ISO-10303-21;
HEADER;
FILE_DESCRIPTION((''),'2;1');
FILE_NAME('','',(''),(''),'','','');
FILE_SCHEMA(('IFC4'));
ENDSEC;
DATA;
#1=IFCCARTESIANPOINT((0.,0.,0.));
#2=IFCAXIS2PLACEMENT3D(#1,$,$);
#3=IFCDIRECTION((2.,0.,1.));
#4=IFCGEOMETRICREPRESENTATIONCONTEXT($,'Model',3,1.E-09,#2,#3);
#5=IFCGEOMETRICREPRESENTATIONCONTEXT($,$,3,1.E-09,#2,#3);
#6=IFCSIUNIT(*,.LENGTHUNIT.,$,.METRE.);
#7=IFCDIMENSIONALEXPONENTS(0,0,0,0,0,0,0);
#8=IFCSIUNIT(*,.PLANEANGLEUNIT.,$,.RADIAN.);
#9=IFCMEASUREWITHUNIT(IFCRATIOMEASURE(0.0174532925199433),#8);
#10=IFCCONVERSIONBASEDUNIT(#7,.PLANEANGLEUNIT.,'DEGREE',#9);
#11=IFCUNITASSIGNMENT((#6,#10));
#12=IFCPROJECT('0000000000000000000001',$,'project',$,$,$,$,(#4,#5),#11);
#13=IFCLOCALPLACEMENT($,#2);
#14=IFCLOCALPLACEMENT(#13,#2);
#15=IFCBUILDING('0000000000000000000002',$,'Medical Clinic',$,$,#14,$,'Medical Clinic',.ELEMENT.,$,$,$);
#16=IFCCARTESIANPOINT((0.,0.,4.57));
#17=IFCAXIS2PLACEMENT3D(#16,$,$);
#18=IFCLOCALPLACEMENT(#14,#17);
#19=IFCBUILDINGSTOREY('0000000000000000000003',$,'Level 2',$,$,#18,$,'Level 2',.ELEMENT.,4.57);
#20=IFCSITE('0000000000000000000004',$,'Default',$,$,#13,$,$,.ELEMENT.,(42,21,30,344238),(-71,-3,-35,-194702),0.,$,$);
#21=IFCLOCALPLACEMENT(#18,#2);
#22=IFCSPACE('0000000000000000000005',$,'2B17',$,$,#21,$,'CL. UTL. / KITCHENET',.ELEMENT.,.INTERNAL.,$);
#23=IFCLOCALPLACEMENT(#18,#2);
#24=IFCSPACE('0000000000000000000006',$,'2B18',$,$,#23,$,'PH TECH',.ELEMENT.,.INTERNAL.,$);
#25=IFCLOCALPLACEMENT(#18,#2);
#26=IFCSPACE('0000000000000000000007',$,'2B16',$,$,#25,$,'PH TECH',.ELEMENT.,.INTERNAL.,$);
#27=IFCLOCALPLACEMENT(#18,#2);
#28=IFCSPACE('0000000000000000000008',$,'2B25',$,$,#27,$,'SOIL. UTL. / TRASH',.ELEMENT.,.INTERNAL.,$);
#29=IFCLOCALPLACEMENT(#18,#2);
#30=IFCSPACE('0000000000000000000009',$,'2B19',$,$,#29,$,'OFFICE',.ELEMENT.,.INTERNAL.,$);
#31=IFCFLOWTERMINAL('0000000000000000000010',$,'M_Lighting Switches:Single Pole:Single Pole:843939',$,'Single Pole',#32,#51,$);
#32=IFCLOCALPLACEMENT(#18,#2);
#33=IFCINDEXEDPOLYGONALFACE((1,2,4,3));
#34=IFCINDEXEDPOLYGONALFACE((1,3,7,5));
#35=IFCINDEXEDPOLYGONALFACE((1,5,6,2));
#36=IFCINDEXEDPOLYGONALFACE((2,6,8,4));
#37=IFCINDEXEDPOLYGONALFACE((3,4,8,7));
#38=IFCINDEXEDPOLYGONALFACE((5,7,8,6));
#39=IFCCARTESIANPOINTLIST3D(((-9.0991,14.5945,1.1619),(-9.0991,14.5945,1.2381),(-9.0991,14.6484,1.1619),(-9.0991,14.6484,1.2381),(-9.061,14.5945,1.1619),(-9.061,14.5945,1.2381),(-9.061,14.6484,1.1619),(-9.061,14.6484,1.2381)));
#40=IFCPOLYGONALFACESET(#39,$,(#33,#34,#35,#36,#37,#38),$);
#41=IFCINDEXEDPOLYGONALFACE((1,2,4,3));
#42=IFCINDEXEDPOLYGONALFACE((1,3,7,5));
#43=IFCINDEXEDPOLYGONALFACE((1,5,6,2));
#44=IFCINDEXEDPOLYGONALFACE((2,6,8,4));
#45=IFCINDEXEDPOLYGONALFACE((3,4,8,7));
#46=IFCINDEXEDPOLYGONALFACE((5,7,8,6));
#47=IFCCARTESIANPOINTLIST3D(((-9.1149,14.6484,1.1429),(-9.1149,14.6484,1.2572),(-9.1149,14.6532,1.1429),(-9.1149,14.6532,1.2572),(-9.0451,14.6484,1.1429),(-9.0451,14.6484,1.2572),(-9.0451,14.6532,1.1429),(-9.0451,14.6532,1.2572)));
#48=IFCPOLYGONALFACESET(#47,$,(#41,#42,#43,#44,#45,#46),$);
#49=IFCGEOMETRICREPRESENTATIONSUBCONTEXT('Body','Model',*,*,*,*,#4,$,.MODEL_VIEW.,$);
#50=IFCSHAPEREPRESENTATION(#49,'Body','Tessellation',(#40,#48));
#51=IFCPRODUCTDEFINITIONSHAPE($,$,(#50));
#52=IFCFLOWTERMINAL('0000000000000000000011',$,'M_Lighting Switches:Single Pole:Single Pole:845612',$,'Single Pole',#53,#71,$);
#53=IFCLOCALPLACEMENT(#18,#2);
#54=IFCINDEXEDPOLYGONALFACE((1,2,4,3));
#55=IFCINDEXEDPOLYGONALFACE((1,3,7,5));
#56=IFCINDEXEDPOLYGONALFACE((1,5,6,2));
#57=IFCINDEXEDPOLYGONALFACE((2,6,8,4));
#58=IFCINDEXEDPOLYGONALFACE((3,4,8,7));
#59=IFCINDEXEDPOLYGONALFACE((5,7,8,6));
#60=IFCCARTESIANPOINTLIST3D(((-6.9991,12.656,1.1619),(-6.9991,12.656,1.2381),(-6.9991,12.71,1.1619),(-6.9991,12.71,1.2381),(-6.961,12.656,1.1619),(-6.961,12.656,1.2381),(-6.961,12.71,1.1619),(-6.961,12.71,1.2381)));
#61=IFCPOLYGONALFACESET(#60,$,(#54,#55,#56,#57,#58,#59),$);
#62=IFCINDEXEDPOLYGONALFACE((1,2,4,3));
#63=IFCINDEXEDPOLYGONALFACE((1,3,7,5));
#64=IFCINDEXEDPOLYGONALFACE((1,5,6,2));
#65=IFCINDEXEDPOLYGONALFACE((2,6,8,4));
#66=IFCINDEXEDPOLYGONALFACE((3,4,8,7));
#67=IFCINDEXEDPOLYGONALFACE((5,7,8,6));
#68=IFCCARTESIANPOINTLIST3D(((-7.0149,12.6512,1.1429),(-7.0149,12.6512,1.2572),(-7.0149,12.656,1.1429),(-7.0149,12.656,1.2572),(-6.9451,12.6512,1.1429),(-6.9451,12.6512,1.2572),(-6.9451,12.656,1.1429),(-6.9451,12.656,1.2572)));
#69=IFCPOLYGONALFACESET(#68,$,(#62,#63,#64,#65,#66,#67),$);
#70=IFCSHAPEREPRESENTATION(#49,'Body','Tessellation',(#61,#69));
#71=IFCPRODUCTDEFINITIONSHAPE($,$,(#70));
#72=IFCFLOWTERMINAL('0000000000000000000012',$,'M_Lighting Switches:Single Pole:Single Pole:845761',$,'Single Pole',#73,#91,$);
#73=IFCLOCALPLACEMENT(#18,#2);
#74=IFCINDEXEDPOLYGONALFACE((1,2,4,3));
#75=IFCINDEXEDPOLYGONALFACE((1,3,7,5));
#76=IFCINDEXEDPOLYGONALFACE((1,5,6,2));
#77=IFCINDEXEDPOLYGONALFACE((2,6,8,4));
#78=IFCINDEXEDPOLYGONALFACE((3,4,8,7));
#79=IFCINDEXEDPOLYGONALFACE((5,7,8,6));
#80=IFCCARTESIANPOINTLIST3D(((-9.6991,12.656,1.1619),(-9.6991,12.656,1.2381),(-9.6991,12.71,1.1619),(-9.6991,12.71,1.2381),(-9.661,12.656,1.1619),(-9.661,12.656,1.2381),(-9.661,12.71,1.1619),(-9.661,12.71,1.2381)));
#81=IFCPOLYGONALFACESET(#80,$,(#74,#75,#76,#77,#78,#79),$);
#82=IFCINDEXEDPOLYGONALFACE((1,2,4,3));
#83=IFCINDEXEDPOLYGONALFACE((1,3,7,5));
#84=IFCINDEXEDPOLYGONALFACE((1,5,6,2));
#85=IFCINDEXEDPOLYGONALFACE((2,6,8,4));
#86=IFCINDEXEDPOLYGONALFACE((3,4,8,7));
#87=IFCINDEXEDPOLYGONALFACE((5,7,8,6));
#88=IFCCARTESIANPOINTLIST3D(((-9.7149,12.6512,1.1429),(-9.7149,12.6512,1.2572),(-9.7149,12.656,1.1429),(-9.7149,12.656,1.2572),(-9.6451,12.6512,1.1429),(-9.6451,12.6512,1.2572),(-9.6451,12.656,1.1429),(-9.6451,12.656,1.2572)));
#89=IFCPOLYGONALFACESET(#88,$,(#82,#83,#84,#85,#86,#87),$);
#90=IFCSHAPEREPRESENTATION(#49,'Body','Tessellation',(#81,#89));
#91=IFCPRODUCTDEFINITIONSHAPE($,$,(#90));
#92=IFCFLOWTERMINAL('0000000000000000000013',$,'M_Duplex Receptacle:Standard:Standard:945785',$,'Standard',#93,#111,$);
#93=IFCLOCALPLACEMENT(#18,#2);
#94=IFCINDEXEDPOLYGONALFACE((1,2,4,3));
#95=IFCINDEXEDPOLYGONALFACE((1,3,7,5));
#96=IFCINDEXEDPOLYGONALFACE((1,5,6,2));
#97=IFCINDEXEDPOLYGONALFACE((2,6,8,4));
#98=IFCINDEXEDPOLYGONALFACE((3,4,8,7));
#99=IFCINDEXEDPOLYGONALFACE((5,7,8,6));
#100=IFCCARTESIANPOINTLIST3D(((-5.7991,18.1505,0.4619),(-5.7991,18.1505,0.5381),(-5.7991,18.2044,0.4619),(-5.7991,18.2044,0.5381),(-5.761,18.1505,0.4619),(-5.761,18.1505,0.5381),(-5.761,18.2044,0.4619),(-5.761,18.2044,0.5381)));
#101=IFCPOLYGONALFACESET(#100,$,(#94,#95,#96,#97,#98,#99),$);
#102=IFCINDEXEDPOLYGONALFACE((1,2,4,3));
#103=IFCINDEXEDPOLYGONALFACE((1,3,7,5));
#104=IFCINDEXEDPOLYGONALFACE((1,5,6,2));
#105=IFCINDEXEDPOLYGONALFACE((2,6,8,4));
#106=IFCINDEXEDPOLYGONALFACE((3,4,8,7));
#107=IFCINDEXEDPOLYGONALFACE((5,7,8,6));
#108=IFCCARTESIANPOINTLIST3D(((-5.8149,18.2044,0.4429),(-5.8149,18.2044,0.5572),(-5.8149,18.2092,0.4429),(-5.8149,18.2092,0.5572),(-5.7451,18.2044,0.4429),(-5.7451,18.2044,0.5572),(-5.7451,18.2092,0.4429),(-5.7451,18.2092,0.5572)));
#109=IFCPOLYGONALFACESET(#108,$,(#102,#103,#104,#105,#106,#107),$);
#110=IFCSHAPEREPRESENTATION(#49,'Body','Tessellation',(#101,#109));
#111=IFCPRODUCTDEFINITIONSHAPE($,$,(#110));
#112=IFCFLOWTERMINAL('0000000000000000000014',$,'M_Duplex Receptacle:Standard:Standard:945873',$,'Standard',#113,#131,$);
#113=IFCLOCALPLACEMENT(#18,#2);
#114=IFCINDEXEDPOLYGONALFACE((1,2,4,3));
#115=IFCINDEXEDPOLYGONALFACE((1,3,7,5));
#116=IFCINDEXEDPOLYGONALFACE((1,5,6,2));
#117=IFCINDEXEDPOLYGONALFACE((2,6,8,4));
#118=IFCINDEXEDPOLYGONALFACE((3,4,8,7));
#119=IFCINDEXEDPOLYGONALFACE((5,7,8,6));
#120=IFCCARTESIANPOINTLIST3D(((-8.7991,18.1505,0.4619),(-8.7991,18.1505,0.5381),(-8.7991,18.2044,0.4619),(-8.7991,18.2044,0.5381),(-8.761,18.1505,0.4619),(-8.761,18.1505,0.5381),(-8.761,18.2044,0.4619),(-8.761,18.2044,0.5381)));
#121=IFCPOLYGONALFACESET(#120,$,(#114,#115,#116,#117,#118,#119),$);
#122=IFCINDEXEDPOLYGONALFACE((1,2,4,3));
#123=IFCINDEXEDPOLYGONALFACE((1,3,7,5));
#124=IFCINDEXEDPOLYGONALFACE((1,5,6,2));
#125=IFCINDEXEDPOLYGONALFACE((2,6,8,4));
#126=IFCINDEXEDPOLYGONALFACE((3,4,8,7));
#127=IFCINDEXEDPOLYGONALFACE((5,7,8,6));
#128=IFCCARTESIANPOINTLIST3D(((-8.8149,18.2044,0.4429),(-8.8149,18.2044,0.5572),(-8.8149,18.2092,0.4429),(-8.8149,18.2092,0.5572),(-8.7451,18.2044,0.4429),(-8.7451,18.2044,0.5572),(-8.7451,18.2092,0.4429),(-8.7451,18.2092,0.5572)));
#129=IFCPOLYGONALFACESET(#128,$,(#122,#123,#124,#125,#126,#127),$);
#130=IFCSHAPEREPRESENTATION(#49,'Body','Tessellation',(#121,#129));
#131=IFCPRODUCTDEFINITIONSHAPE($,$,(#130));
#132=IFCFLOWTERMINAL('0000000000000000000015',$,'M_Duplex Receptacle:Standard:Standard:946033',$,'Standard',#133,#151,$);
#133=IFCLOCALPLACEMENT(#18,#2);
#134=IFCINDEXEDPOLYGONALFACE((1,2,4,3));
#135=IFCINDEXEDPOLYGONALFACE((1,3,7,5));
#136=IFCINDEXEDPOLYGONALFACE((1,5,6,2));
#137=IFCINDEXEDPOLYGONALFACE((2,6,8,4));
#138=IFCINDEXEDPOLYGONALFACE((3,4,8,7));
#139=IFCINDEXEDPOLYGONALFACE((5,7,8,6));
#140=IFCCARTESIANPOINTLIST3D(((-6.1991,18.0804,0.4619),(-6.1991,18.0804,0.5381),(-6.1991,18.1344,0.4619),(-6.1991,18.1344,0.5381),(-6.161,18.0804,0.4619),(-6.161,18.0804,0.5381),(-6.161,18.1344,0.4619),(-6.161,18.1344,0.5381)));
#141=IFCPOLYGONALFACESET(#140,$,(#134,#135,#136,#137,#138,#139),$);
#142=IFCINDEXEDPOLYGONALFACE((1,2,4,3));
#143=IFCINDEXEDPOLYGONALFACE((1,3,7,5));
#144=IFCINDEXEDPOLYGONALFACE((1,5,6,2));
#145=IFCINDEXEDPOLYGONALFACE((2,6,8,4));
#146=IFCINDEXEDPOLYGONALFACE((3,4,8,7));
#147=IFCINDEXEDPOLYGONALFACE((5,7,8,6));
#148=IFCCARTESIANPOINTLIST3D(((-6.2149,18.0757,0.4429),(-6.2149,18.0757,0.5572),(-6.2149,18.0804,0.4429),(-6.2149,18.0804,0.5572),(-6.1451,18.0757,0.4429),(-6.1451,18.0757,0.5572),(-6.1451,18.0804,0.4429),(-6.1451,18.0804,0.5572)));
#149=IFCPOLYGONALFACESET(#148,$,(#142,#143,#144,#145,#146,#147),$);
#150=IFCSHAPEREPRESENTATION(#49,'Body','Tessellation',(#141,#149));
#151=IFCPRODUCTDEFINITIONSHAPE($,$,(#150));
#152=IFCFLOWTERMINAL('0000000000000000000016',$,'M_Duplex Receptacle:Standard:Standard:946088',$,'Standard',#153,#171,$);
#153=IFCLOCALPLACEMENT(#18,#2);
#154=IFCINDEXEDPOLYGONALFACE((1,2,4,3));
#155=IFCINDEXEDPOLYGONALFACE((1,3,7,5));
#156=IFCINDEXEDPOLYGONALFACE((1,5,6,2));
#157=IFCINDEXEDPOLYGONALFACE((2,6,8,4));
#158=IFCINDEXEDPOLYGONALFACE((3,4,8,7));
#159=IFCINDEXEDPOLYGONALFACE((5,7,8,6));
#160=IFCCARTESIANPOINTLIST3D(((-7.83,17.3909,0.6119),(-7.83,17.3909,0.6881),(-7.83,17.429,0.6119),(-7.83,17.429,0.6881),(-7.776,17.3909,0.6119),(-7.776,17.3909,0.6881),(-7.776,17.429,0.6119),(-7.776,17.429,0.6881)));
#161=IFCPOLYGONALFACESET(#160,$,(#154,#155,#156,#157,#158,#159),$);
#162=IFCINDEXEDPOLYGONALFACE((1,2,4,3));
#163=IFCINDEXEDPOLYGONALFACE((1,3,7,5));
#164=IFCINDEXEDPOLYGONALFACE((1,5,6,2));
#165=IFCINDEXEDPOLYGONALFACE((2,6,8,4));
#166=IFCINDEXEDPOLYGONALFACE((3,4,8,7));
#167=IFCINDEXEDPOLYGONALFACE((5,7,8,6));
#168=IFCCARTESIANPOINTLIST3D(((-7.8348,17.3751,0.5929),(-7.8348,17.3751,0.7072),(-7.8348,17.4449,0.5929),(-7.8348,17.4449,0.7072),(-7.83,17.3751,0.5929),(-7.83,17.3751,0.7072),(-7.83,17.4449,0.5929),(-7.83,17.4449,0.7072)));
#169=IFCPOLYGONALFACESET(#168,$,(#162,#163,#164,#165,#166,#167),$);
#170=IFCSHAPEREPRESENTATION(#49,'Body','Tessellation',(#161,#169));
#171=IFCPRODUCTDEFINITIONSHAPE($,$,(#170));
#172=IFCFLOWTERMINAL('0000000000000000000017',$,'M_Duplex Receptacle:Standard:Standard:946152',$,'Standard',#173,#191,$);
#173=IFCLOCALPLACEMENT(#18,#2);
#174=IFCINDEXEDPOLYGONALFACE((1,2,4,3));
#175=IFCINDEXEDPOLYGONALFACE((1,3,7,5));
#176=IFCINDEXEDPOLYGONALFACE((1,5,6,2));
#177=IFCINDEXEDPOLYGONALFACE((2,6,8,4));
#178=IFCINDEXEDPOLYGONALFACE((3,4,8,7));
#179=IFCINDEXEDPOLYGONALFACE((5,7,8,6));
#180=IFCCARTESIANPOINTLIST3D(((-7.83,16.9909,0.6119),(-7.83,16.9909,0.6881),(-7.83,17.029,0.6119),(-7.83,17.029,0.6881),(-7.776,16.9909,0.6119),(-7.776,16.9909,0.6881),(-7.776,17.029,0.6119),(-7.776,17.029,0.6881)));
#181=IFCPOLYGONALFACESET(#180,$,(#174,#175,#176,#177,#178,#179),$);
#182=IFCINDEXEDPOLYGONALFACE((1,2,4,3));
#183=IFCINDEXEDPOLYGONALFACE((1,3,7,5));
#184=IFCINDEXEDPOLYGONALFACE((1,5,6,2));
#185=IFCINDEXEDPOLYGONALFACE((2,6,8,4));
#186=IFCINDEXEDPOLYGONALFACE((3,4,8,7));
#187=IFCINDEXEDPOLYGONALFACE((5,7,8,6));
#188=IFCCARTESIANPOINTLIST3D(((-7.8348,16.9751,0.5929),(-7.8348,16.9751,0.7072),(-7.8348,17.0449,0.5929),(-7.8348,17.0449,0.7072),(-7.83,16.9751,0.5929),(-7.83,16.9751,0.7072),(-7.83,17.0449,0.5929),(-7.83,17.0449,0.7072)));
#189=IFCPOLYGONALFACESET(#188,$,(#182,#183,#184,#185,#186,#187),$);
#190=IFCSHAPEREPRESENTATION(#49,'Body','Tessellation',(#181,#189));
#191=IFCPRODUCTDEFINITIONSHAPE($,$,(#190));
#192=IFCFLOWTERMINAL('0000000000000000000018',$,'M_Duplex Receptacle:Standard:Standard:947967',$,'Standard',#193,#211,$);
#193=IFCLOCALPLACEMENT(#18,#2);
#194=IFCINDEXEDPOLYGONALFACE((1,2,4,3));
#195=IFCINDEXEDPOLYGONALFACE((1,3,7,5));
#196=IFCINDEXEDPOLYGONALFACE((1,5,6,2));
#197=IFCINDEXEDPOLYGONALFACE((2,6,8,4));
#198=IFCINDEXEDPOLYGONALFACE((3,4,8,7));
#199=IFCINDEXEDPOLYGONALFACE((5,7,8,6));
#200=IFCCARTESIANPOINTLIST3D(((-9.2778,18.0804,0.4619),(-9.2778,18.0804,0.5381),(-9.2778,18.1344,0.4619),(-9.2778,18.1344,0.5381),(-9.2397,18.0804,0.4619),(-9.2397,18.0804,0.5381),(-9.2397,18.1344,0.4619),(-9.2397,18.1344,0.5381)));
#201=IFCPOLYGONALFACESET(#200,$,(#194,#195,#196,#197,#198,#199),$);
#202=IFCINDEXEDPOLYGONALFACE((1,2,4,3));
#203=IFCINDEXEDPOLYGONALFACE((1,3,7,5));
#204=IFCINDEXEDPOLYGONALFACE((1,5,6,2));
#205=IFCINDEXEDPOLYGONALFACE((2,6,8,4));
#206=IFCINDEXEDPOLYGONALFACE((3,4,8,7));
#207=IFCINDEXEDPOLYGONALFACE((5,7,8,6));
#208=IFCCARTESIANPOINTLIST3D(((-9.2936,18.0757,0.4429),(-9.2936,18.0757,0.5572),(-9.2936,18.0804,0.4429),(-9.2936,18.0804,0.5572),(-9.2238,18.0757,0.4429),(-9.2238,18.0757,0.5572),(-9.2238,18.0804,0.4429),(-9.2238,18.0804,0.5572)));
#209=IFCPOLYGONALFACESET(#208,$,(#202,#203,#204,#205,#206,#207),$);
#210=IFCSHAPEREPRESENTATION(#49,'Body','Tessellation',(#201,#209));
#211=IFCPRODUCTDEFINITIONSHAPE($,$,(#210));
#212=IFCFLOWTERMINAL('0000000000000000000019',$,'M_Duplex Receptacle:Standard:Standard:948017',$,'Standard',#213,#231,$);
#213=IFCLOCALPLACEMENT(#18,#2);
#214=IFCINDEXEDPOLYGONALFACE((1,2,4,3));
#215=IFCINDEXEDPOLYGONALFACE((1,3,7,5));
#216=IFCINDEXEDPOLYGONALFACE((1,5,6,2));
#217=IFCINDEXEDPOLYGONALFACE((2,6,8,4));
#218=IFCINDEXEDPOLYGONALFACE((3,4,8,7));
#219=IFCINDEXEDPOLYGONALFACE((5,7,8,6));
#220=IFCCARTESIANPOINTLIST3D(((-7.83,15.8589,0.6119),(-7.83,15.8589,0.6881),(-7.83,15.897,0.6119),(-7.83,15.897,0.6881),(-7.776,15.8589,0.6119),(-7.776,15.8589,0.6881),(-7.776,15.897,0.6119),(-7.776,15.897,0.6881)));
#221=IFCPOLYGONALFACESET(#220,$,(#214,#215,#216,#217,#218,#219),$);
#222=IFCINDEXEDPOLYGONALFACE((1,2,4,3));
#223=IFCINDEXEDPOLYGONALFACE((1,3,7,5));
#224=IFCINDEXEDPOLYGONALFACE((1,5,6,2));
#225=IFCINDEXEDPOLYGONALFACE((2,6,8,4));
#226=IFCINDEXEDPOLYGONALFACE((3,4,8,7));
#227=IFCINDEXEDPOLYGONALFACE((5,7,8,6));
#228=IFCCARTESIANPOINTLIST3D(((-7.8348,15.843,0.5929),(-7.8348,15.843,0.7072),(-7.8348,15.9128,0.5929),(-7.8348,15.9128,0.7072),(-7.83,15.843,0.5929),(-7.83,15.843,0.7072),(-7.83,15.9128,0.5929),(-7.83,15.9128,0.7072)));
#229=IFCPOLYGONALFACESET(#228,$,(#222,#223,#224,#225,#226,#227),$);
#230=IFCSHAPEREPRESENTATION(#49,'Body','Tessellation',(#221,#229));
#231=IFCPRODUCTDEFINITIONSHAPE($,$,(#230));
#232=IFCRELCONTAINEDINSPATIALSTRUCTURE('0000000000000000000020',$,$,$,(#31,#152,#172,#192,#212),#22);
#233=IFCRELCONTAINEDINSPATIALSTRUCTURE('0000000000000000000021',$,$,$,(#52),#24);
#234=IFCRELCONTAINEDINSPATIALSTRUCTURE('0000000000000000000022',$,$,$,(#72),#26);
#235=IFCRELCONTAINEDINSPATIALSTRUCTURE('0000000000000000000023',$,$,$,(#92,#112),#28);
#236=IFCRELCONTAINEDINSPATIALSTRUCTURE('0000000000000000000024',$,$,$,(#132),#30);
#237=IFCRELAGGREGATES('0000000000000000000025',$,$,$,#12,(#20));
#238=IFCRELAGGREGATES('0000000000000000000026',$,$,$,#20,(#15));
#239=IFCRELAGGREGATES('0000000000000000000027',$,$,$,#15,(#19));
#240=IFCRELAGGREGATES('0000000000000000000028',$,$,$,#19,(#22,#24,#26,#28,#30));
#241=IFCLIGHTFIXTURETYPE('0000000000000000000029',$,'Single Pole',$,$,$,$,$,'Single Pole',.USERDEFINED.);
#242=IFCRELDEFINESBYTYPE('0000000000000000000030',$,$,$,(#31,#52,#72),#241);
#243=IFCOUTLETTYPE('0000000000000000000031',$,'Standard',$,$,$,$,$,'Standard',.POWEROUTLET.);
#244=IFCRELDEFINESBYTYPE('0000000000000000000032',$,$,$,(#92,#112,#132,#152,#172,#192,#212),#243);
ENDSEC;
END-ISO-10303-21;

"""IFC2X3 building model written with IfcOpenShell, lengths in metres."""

from ifc_helpers import new_model, entity, si_unit, converted_unit, direction, frame, frame_2d, origin, origin_2d_with_axis, place, context, subcontext, project, spatial, rectangle, extrude, source, transform, mapped, type_object, type_shapes, element, save


model = new_model("IFC2X3")

# Units and contexts
model_context = context("Model", 3, precision=1e-09, world=origin(), true_north=direction((2.0, 0.0, 1.0)))
context_of_model = context(None, 3, precision=1e-09, world=origin(), true_north=direction((2.0, 0.0, 1.0)))
body_context = subcontext(model_context, "Body", "Model", "MODEL_VIEW")
ifc_project = project(units=[si_unit("LENGTHUNIT", "METRE"), converted_unit("PLANEANGLEUNIT", "DEGREE", entity("IfcRatioMeasure", 0.0174532925199433), si_unit("PLANEANGLEUNIT", "RADIAN"), dimensions=[0, 0, 0, 0, 0, 0, 0])], contexts=[model_context, context_of_model])

# Site, building, storey
site_placement = place(None, origin())
site = spatial("IfcSite", under=ifc_project, at=site_placement, Name="Default", CompositionType="ELEMENT", RefLatitude=(42, 21, 30, 344238), RefLongitude=(-71, -3, -35, -194702), RefElevation=0.0)
building_placement = place(site_placement, origin())
building = spatial("IfcBuilding", under=site, at=building_placement, Name="Medical Clinic", LongName="Medical Clinic", CompositionType="ELEMENT")
storey_placement = place(building_placement, frame((0.0, 0.0, 4.57)))
storey = spatial("IfcBuildingStorey", under=building, at=storey_placement, Name="Level 2", LongName="Level 2", CompositionType="ELEMENT", Elevation=4.57)

# Shared definitions
space_1_placement = place(storey_placement, origin())
space_1 = spatial("IfcSpace", under=storey, at=space_1_placement, Name="2B17", LongName="CL. UTL. / KITCHENET", CompositionType="ELEMENT", InteriorOrExteriorSpace="INTERNAL")

# Flow terminal
light_fixture_type_1 = type_object("IfcLightFixtureType", Name="Single Pole", ElementType="Single Pole", PredefinedType="USERDEFINED")
shared_shape_1 = source(origin(), body_context, "Body", "SweptSolid", [
    extrude(rectangle(XDim=0.0381, YDim=0.0762, at=origin_2d_with_axis()), frame((0.0, 0.0, -0.054), z_axis=(0.0, 0.0, 1.0), x_axis=(-1.0, 0.0, 0.0)), (0.0, 0.0, 1.0), 0.054),
    extrude(rectangle(XDim=0.0698, YDim=0.1143, at=frame_2d((0.0, 0.0), x_axis=(1.0, 0.0))), frame((0.0, 0.0, 0.0), z_axis=(0.0, 0.0, 1.0), x_axis=(-1.0, 0.0, 0.0)), (0.0, 0.0, 1.0), 0.0048),
])
type_shapes(light_fixture_type_1, [shared_shape_1])
flow_terminal_1_placement = place(space_1_placement, frame((-9.08, 14.6484, 1.2), z_axis=(0.0, 1.0, 0.0), x_axis=(-1.0, 0.0, 0.0)))
element("IfcFlowTerminal", 1, at=flow_terminal_1_placement, inside=space_1, type_object=light_fixture_type_1, Name="M_Lighting Switches:Single Pole:Single Pole:843939", ObjectType="Single Pole", context=body_context, shape_type="MappedRepresentation", body=[
    mapped(shared_shape_1, transform((0.0, 0.0, 0.0), scale=1.0)),
])

# Shared definitions
space_2_placement = place(storey_placement, origin())
space_2 = spatial("IfcSpace", under=storey, at=space_2_placement, Name="2B18", LongName="PH TECH", CompositionType="ELEMENT", InteriorOrExteriorSpace="INTERNAL")

# Flow terminal
flow_terminal_2_placement = place(space_2_placement, frame((-6.98, 12.656, 1.2), z_axis=(0.0, -1.0, 0.0), x_axis=(1.0, 0.0, 0.0)))
element("IfcFlowTerminal", 2, at=flow_terminal_2_placement, inside=space_2, type_object=light_fixture_type_1, Name="M_Lighting Switches:Single Pole:Single Pole:845612", ObjectType="Single Pole", context=body_context, shape_type="MappedRepresentation", body=[
    mapped(shared_shape_1, transform((0.0, 0.0, 0.0), scale=1.0)),
])

# Shared definitions
space_3_placement = place(storey_placement, origin())
space_3 = spatial("IfcSpace", under=storey, at=space_3_placement, Name="2B16", LongName="PH TECH", CompositionType="ELEMENT", InteriorOrExteriorSpace="INTERNAL")

# Flow terminal
flow_terminal_3_placement = place(space_3_placement, frame((-9.68, 12.656, 1.2), z_axis=(0.0, -1.0, 0.0), x_axis=(1.0, 0.0, 0.0)))
element("IfcFlowTerminal", 3, at=flow_terminal_3_placement, inside=space_3, type_object=light_fixture_type_1, Name="M_Lighting Switches:Single Pole:Single Pole:845761", ObjectType="Single Pole", context=body_context, shape_type="MappedRepresentation", body=[
    mapped(shared_shape_1, transform((0.0, 0.0, 0.0), scale=1.0)),
])

# Shared definitions
space_4_placement = place(storey_placement, origin())
space_4 = spatial("IfcSpace", under=storey, at=space_4_placement, Name="2B25", LongName="SOIL. UTL. / TRASH", CompositionType="ELEMENT", InteriorOrExteriorSpace="INTERNAL")

# Flow terminals
outlet_type = type_object("IfcOutletType", Name="Standard", ElementType="Standard", PredefinedType="POWEROUTLET")
shared_shape_2 = source(origin(), body_context, "Body", "SweptSolid", [
    extrude(rectangle(XDim=0.0381, YDim=0.0762, at=origin_2d_with_axis()), frame((0.0, 0.0, -0.054), z_axis=(0.0, 0.0, 1.0), x_axis=(-1.0, 0.0, 0.0)), (0.0, 0.0, 1.0), 0.054),
    extrude(rectangle(XDim=0.0698, YDim=0.1143, at=frame_2d((0.0, 0.0), x_axis=(1.0, 0.0))), frame((0.0, 0.0, 0.0), z_axis=(0.0, 0.0, 1.0), x_axis=(-1.0, 0.0, 0.0)), (0.0, 0.0, 1.0), 0.0048),
])
type_shapes(outlet_type, [shared_shape_2])
for number, where, z_axis, x_axis, name in (
    (4, (-5.78, 18.2044, 0.5), (0.0, 1.0, 0.0), (-1.0, 0.0, 0.0), "M_Duplex Receptacle:Standard:Standard:945785"),
    (5, (-8.78, 18.2044, 0.5), (0.0, 1.0, 0.0), (-1.0, 0.0, 0.0), "M_Duplex Receptacle:Standard:Standard:945873"),
):
    element("IfcFlowTerminal", number, at=place(space_4_placement, frame(where, z_axis=z_axis, x_axis=x_axis)), inside=space_4, type_object=outlet_type, Name=name, ObjectType="Standard", context=body_context, shape_type="MappedRepresentation", body=[
        mapped(shared_shape_2, transform((0.0, 0.0, 0.0), scale=1.0)),
    ])

# Shared definitions
space_5_placement = place(storey_placement, origin())
space_5 = spatial("IfcSpace", under=storey, at=space_5_placement, Name="2B19", LongName="OFFICE", CompositionType="ELEMENT", InteriorOrExteriorSpace="INTERNAL")

# Flow terminals
flow_terminal_4_placement = place(space_5_placement, frame((-6.18, 18.0804, 0.5), z_axis=(0.0, -1.0, 0.0), x_axis=(1.0, 0.0, 0.0)))
element("IfcFlowTerminal", 6, at=flow_terminal_4_placement, inside=space_5, type_object=outlet_type, Name="M_Duplex Receptacle:Standard:Standard:946033", ObjectType="Standard", context=body_context, shape_type="MappedRepresentation", body=[
    mapped(shared_shape_2, transform((0.0, 0.0, 0.0), scale=1.0)),
])
for number, where, z_axis, x_axis, name in (
    (7, (-7.83, 17.41, 0.65), (-1.0, 0.0, 0.0), (0.0, -1.0, 0.0), "M_Duplex Receptacle:Standard:Standard:946088"),
    (8, (-7.83, 17.01, 0.65), (-1.0, 0.0, 0.0), (0.0, -1.0, 0.0), "M_Duplex Receptacle:Standard:Standard:946152"),
    (9, (-9.2587, 18.0804, 0.5), (0.0, -1.0, 0.0), (1.0, 0.0, 0.0), "M_Duplex Receptacle:Standard:Standard:947967"),
    (10, (-7.83, 15.8779, 0.65), (-1.0, 0.0, 0.0), (0.0, -1.0, 0.0), "M_Duplex Receptacle:Standard:Standard:948017"),
):
    element("IfcFlowTerminal", number, at=place(space_1_placement, frame(where, z_axis=z_axis, x_axis=x_axis)), inside=space_1, type_object=outlet_type, Name=name, ObjectType="Standard", context=body_context, shape_type="MappedRepresentation", body=[
        mapped(shared_shape_2, transform((0.0, 0.0, 0.0), scale=1.0)),
    ])

save(model, "model.ifc")
